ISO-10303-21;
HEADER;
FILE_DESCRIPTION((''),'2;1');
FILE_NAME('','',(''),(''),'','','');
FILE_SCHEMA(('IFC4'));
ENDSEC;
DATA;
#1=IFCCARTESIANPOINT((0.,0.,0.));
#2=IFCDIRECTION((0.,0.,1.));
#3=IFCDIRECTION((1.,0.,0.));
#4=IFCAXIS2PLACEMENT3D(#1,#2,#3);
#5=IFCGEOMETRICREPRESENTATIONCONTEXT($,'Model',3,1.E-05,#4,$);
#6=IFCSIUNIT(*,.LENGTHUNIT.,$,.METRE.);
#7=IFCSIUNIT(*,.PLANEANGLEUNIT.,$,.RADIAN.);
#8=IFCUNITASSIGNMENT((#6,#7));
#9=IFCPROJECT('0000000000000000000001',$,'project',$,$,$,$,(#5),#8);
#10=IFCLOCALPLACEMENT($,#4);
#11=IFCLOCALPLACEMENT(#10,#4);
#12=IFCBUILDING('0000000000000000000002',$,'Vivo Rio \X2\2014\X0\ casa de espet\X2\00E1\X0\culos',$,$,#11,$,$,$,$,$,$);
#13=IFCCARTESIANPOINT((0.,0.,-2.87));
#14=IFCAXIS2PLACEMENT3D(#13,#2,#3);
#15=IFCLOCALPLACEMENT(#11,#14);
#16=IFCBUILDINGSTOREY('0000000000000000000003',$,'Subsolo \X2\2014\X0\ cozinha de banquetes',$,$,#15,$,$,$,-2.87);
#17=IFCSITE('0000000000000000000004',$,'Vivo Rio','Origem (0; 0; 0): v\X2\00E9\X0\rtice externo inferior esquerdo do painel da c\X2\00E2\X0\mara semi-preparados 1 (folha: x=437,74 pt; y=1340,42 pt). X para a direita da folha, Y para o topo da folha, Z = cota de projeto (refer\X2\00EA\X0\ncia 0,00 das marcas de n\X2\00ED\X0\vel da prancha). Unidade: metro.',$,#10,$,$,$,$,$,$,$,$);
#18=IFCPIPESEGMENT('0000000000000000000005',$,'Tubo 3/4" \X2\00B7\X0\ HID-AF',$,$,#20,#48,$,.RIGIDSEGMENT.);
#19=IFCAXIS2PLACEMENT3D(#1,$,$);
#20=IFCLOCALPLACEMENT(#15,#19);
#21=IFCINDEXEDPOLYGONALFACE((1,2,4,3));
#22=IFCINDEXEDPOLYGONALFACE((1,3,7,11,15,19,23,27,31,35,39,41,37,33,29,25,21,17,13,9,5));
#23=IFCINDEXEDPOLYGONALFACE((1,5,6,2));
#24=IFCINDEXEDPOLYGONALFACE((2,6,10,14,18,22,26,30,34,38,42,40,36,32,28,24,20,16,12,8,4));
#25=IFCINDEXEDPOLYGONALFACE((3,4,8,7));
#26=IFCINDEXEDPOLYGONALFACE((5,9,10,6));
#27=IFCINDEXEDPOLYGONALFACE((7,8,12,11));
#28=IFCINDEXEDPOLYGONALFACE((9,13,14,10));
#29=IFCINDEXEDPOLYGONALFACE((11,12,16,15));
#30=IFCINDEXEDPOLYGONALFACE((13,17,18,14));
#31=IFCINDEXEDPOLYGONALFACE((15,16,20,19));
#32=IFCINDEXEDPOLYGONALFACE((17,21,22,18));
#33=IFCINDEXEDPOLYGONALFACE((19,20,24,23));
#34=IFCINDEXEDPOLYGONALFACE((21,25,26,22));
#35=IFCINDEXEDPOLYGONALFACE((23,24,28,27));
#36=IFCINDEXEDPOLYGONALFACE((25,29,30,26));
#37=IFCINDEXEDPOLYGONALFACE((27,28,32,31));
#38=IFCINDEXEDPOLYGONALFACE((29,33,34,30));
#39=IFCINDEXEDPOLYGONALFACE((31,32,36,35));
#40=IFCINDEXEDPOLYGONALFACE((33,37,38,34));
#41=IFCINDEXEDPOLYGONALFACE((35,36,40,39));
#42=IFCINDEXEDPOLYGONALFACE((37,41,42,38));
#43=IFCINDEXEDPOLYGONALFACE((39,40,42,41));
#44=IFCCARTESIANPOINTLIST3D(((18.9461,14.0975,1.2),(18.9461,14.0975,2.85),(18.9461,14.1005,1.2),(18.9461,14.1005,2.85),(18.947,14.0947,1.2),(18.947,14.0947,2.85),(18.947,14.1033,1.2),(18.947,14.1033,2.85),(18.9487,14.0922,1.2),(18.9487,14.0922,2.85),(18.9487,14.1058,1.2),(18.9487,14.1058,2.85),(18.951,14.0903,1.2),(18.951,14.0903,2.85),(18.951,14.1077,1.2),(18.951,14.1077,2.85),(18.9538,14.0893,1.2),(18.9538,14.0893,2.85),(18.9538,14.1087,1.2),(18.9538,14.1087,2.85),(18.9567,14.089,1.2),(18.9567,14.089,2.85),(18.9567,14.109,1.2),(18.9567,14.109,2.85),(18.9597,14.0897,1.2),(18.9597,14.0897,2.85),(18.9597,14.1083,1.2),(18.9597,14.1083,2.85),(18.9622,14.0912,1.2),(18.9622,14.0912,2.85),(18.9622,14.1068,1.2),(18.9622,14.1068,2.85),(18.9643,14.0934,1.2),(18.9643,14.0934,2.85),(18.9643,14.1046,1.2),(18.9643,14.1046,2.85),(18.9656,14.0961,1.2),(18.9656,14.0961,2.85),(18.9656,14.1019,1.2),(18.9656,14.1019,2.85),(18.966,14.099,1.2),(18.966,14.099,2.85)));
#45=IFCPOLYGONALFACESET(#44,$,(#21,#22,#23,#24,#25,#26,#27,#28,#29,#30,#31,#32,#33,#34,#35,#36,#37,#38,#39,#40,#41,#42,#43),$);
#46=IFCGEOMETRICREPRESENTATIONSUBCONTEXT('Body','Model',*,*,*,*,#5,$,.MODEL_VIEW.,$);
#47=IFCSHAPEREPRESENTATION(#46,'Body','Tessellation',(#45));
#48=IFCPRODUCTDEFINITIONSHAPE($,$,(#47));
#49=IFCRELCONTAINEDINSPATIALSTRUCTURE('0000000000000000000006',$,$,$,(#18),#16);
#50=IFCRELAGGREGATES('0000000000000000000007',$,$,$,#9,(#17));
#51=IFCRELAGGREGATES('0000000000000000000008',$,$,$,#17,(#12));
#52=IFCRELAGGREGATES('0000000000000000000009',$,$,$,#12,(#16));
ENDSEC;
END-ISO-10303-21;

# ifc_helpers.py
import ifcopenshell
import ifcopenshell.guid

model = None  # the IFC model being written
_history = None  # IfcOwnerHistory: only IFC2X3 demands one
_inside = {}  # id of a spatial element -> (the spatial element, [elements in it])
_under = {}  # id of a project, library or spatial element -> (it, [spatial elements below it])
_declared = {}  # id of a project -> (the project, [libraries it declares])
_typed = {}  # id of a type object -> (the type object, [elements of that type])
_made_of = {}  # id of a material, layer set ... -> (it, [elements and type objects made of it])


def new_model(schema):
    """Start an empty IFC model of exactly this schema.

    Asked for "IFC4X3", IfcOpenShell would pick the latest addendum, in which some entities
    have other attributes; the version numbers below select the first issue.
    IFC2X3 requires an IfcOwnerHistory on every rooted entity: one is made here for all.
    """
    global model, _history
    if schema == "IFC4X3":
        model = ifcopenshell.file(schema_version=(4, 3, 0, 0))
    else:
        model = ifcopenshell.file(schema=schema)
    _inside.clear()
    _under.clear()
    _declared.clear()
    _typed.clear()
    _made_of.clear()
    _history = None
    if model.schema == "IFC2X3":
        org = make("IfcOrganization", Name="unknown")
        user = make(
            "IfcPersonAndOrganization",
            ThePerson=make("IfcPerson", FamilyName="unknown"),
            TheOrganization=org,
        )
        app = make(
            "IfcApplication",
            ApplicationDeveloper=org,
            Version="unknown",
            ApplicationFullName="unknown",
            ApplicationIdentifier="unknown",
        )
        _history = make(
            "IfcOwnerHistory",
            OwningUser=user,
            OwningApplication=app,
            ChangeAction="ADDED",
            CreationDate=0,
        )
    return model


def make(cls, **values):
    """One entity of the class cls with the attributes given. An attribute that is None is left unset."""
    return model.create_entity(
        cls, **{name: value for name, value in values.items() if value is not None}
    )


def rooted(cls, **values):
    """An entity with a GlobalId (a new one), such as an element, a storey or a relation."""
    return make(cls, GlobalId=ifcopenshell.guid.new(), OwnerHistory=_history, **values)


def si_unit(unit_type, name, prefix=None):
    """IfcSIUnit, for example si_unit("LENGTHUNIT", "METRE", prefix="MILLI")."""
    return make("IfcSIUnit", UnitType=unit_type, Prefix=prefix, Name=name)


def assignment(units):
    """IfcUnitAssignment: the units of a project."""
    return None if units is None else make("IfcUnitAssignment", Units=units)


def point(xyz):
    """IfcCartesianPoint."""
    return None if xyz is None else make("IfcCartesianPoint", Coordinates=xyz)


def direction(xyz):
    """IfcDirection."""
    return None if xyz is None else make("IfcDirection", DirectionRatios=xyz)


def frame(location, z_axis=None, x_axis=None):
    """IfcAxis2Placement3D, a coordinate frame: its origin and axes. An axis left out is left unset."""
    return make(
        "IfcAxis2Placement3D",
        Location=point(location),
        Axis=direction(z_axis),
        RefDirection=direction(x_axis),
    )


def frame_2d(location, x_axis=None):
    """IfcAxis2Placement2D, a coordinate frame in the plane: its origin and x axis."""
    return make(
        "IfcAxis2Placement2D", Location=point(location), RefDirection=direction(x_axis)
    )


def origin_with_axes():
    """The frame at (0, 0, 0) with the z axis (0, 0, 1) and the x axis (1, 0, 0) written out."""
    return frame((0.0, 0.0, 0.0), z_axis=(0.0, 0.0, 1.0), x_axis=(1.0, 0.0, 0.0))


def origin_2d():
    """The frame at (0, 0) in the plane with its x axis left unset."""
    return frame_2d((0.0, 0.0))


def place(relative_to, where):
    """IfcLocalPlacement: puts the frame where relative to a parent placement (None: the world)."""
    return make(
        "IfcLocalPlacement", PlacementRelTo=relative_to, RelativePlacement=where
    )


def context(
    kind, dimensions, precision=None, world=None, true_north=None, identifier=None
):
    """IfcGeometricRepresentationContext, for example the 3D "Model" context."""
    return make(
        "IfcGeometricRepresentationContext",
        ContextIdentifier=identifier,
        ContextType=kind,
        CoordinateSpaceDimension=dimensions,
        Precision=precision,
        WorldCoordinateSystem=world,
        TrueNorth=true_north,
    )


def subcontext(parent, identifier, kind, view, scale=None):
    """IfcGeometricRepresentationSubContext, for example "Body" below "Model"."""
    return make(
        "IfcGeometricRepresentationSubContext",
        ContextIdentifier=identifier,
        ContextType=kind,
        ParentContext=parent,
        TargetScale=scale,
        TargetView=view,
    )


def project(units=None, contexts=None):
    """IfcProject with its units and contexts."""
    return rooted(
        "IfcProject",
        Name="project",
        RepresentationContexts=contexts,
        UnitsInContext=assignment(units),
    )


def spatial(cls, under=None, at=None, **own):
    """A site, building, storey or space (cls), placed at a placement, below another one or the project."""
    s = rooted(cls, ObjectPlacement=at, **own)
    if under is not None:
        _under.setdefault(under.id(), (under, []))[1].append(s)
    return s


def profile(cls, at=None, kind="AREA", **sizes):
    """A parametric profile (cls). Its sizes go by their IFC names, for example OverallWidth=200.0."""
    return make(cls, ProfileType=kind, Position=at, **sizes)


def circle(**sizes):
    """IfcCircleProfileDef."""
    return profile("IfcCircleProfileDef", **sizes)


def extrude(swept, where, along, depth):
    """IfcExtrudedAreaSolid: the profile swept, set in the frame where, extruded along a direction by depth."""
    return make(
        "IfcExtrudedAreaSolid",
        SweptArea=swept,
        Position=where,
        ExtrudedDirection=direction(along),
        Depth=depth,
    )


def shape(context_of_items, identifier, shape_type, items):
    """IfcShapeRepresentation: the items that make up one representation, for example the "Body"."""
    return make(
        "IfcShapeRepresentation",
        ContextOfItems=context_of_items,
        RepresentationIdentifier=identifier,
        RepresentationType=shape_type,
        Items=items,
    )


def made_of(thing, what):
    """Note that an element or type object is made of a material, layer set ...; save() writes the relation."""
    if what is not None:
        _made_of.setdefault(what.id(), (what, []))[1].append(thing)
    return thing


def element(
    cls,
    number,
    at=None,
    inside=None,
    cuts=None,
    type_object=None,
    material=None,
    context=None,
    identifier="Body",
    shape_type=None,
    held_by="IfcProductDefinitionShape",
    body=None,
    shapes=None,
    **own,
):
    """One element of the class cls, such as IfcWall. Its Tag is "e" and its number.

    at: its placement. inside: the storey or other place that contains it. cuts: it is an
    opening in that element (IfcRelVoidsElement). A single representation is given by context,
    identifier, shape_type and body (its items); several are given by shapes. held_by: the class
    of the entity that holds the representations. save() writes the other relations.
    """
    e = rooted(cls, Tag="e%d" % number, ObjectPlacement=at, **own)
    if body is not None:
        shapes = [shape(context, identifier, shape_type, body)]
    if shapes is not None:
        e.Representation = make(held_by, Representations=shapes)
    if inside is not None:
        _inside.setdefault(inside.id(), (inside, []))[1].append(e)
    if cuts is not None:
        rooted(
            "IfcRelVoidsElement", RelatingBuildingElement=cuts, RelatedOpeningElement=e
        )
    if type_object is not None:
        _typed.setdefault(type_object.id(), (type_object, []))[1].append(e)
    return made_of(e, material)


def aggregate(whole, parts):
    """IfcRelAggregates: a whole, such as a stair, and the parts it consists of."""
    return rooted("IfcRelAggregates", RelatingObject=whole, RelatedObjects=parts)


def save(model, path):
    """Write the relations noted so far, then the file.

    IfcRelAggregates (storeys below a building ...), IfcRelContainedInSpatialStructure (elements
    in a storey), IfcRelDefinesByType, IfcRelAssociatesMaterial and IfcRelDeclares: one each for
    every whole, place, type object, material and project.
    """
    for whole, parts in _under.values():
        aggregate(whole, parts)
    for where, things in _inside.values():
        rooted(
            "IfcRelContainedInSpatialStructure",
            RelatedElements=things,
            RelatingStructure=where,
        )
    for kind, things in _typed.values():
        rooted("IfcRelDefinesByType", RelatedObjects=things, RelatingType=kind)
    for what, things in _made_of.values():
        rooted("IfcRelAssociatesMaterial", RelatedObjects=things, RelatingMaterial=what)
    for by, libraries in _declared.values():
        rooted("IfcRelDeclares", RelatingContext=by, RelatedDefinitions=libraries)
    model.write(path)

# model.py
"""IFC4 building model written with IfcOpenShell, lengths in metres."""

from ifc_helpers import new_model, si_unit, frame, origin_with_axes, origin_2d, place, context, subcontext, project, spatial, circle, extrude, element, save


model = new_model("IFC4")

# Units and contexts
model_context = context("Model", 3, precision=1e-05, world=origin_with_axes())
body_context = subcontext(model_context, "Body", "Model", "MODEL_VIEW")
ifc_project = project(units=[si_unit("LENGTHUNIT", "METRE"), si_unit("PLANEANGLEUNIT", "RADIAN")], contexts=[model_context])

# Site, building, storey
site_placement = place(None, origin_with_axes())
site = spatial("IfcSite", under=ifc_project, at=site_placement, Name="Vivo Rio", Description="Origem (0; 0; 0): vértice externo inferior esquerdo do painel da câmara semi-preparados 1 (folha: x=437,74 pt; y=1340,42 pt). X para a direita da folha, Y para o topo da folha, Z = cota de projeto (referência 0,00 das marcas de nível da prancha). Unidade: metro.")
building_placement = place(site_placement, origin_with_axes())
building = spatial("IfcBuilding", under=site, at=building_placement, Name="Vivo Rio — casa de espetáculos")
storey_placement = place(building_placement, frame((0.0, 0.0, -2.87), z_axis=(0.0, 0.0, 1.0), x_axis=(1.0, 0.0, 0.0)))
storey = spatial("IfcBuildingStorey", under=building, at=storey_placement, Name="Subsolo — cozinha de banquetes", Elevation=-2.87)

# Pipe segment
pipe_segment_1_placement = place(storey_placement, origin_with_axes())
element("IfcPipeSegment", 1, at=pipe_segment_1_placement, inside=storey, Name="Tubo 3/4\" · HID-AF", PredefinedType="RIGIDSEGMENT", context=body_context, shape_type="SweptSolid", body=[
    extrude(circle(Radius=0.01, at=origin_2d()), frame((18.956, 14.099, 2.85), z_axis=(0.0, 0.0, -1.0), x_axis=(1.0, 0.0, 0.0)), (0.0, 0.0, 1.0), 1.65),
])

save(model, "model.ifc")
